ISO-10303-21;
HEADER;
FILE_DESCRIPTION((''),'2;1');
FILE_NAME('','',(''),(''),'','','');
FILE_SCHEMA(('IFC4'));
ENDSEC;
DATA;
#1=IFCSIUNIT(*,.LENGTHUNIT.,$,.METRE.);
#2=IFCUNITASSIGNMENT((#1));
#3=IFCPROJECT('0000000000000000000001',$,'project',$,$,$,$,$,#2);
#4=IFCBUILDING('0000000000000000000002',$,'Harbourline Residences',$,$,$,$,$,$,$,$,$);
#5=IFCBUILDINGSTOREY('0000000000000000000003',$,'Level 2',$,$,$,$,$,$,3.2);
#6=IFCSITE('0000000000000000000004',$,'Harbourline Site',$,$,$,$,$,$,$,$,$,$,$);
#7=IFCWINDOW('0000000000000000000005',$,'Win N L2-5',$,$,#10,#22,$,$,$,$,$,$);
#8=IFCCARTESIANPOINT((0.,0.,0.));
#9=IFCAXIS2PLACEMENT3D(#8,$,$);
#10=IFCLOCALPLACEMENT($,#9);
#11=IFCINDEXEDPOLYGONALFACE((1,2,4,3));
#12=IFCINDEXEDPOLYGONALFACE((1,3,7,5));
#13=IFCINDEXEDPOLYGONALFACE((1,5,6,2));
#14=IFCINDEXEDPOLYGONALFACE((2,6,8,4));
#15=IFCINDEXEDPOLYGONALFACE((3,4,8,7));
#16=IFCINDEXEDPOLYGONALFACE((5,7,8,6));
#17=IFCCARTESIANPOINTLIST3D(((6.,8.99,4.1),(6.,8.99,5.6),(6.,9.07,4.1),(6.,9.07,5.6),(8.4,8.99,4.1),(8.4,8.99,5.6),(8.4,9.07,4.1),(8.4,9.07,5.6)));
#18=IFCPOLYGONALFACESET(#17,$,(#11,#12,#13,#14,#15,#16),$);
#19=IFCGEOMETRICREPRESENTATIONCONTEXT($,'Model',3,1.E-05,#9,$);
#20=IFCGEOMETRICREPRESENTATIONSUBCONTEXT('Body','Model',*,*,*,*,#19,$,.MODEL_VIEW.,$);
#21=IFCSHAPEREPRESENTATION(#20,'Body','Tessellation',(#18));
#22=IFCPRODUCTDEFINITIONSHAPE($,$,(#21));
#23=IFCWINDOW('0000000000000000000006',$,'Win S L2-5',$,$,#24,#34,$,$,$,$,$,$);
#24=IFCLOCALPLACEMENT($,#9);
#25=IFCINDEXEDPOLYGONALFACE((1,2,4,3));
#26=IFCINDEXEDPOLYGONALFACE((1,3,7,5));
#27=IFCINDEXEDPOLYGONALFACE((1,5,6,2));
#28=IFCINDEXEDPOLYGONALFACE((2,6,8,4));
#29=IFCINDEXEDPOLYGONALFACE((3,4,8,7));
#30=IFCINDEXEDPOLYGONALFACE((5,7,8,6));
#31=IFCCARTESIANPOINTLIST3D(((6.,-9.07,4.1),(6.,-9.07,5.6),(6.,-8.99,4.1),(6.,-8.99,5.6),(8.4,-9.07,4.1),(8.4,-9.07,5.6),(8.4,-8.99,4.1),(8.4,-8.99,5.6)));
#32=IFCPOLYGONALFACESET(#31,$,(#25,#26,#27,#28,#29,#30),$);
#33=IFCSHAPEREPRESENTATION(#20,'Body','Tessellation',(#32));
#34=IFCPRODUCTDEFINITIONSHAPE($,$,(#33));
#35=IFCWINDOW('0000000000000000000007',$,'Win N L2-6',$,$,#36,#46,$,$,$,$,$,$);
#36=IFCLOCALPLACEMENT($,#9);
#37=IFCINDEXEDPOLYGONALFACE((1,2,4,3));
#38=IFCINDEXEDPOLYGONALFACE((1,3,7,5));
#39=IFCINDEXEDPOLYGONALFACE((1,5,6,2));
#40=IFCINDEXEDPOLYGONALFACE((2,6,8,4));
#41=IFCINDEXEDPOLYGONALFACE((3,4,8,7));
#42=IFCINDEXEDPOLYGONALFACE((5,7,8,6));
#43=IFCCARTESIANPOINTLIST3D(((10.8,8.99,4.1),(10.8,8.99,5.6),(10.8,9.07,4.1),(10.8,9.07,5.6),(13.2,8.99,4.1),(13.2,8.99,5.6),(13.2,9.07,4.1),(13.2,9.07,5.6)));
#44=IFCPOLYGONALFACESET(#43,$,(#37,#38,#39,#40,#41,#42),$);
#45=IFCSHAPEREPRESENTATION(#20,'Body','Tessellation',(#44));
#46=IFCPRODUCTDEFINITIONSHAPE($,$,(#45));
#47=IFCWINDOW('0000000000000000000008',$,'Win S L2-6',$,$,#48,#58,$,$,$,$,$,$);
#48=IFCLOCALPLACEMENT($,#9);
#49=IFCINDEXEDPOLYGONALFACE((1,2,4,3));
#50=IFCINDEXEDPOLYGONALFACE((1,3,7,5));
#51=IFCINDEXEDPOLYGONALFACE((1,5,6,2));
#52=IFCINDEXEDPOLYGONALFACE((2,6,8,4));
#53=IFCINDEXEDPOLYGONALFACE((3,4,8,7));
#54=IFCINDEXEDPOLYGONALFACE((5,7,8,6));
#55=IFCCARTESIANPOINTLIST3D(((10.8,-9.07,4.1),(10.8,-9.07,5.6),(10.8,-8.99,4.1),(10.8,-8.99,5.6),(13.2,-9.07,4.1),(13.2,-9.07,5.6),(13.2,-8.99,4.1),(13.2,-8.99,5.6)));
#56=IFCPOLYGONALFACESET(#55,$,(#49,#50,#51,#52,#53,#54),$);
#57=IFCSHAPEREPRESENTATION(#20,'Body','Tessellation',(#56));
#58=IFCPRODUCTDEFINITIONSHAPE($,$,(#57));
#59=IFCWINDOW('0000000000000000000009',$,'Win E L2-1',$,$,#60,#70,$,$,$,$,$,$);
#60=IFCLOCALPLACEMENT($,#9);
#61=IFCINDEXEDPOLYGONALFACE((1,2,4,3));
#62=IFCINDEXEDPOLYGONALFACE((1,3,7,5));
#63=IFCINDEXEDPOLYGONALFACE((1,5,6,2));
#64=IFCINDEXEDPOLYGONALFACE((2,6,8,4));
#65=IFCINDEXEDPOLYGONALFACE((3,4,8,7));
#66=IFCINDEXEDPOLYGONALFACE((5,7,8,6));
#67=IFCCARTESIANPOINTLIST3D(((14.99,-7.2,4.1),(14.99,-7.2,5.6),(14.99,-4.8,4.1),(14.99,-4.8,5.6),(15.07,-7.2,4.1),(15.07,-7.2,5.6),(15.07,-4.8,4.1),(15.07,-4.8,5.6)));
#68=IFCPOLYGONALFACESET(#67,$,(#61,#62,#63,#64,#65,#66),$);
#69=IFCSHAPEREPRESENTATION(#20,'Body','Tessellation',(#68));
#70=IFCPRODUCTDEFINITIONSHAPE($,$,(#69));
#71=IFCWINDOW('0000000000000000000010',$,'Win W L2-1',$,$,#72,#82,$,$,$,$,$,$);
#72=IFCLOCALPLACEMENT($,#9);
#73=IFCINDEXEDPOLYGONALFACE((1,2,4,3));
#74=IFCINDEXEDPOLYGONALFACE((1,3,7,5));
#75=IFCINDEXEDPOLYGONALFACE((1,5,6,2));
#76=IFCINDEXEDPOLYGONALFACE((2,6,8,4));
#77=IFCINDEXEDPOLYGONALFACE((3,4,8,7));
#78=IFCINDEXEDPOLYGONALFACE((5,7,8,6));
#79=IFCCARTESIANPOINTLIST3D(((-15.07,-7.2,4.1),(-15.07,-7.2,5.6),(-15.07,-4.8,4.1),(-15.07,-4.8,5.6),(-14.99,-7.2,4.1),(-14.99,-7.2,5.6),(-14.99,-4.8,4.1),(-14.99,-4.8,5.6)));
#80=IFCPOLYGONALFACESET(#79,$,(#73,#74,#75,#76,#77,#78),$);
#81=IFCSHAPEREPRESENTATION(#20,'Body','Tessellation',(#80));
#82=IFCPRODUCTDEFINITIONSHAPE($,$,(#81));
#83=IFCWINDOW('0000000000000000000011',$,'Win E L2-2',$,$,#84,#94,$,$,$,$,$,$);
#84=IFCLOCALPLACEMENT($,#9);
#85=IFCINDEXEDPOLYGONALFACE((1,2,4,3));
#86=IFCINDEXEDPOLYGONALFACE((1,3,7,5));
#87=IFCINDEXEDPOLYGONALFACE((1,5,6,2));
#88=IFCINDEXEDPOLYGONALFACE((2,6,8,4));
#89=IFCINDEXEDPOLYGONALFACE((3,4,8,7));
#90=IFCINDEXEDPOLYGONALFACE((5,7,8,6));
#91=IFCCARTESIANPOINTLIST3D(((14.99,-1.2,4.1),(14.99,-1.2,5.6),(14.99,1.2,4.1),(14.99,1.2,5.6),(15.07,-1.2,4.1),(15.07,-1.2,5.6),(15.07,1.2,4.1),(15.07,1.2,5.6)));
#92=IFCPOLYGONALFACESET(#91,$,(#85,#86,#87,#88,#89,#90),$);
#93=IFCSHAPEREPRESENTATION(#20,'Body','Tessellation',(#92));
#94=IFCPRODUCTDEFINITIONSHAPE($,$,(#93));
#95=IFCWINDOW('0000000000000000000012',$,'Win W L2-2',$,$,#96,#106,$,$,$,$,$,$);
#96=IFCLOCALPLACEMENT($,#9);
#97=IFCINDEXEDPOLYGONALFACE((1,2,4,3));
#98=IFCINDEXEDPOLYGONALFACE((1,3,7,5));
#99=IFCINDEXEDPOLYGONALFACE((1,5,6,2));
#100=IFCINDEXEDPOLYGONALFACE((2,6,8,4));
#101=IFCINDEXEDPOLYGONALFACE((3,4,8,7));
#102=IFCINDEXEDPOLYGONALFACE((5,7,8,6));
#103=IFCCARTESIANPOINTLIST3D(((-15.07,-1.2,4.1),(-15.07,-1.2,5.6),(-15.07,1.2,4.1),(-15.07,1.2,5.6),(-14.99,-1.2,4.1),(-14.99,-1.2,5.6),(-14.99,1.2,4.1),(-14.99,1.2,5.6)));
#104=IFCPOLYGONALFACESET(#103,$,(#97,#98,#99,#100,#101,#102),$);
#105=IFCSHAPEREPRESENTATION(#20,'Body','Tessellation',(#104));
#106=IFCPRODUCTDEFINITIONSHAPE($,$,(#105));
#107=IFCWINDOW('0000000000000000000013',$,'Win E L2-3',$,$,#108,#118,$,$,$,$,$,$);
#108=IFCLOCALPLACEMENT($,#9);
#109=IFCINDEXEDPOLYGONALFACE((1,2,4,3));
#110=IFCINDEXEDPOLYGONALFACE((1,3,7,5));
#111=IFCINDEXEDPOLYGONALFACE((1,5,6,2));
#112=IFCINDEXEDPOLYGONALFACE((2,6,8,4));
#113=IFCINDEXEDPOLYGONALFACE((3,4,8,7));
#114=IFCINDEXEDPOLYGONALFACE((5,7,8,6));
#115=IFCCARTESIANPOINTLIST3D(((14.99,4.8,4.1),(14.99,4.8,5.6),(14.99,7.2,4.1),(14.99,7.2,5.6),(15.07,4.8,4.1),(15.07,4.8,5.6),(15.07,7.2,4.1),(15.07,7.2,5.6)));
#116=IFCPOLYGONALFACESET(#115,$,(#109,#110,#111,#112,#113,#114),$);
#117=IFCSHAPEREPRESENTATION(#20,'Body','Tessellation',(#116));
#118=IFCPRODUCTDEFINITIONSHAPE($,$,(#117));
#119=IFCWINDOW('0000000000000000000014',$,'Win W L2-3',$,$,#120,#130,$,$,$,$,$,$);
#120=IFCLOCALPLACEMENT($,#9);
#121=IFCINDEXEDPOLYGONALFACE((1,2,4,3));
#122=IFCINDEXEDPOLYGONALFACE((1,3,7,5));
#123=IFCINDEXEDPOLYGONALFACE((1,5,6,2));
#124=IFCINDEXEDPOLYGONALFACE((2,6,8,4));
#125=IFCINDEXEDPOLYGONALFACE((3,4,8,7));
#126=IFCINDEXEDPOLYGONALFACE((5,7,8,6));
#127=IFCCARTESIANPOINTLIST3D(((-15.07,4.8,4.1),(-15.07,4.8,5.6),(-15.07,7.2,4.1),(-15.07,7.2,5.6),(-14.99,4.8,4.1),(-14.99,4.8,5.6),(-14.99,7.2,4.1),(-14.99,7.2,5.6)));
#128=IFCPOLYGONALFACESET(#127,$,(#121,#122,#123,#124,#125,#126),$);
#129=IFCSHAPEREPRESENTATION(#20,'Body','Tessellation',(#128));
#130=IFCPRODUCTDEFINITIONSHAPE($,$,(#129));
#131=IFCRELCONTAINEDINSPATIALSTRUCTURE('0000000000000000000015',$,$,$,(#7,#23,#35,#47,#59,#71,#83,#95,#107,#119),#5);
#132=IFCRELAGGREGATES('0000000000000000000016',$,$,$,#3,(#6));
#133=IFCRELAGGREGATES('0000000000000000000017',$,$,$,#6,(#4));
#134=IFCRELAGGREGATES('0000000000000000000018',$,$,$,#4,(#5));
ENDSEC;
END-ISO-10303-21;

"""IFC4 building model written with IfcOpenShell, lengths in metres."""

from ifc_helpers import new_model, si_unit, frame, frame_2d, origin, context, subcontext, project, spatial, rectangle, extrude, element, save


model = new_model("IFC4")

# Units and contexts
model_context = context("Model", 3, precision=1e-05, world=origin())
body_context = subcontext(model_context, "Body", "Model", "MODEL_VIEW")
ifc_project = project(units=[si_unit("LENGTHUNIT", "METRE")])

# Site, building, storey
site = spatial("IfcSite", under=ifc_project, Name="Harbourline Site")
building = spatial("IfcBuilding", under=site, Name="Harbourline Residences")
storey = spatial("IfcBuildingStorey", under=building, Name="Level 2", Elevation=3.2)

# Windows
element("IfcWindow", 1, inside=storey, Name="Win N L2-5", context=body_context, shape_type="SweptSolid", body=[
    extrude(rectangle(XDim=2.4, YDim=0.08, at=frame_2d((7.2, 9.03))), frame((0.0, 0.0, 4.1)), (0.0, 0.0, 1.0), 1.5),
])
element("IfcWindow", 2, inside=storey, Name="Win S L2-5", context=body_context, shape_type="SweptSolid", body=[
    extrude(rectangle(XDim=2.4, YDim=0.08, at=frame_2d((7.2, -9.03))), frame((0.0, 0.0, 4.1)), (0.0, 0.0, 1.0), 1.5),
])
element("IfcWindow", 3, inside=storey, Name="Win N L2-6", context=body_context, shape_type="SweptSolid", body=[
    extrude(rectangle(XDim=2.4, YDim=0.08, at=frame_2d((12.0, 9.03))), frame((0.0, 0.0, 4.1)), (0.0, 0.0, 1.0), 1.5),
])
element("IfcWindow", 4, inside=storey, Name="Win S L2-6", context=body_context, shape_type="SweptSolid", body=[
    extrude(rectangle(XDim=2.4, YDim=0.08, at=frame_2d((12.0, -9.03))), frame((0.0, 0.0, 4.1)), (0.0, 0.0, 1.0), 1.5),
])
element("IfcWindow", 5, inside=storey, Name="Win E L2-1", context=body_context, shape_type="SweptSolid", body=[
    extrude(rectangle(XDim=0.08, YDim=2.4, at=frame_2d((15.03, -6.0))), frame((0.0, 0.0, 4.1)), (0.0, 0.0, 1.0), 1.5),
])
element("IfcWindow", 6, inside=storey, Name="Win W L2-1", context=body_context, shape_type="SweptSolid", body=[
    extrude(rectangle(XDim=0.08, YDim=2.4, at=frame_2d((-15.03, -6.0))), frame((0.0, 0.0, 4.1)), (0.0, 0.0, 1.0), 1.5),
])
element("IfcWindow", 7, inside=storey, Name="Win E L2-2", context=body_context, shape_type="SweptSolid", body=[
    extrude(rectangle(XDim=0.08, YDim=2.4, at=frame_2d((15.03, 0.0))), frame((0.0, 0.0, 4.1)), (0.0, 0.0, 1.0), 1.5),
])
element("IfcWindow", 8, inside=storey, Name="Win W L2-2", context=body_context, shape_type="SweptSolid", body=[
    extrude(rectangle(XDim=0.08, YDim=2.4, at=frame_2d((-15.03, 0.0))), frame((0.0, 0.0, 4.1)), (0.0, 0.0, 1.0), 1.5),
])
element("IfcWindow", 9, inside=storey, Name="Win E L2-3", context=body_context, shape_type="SweptSolid", body=[
    extrude(rectangle(XDim=0.08, YDim=2.4, at=frame_2d((15.03, 6.0))), frame((0.0, 0.0, 4.1)), (0.0, 0.0, 1.0), 1.5),
])
element("IfcWindow", 10, inside=storey, Name="Win W L2-3", context=body_context, shape_type="SweptSolid", body=[
    extrude(rectangle(XDim=0.08, YDim=2.4, at=frame_2d((-15.03, 6.0))), frame((0.0, 0.0, 4.1)), (0.0, 0.0, 1.0), 1.5),
])

save(model, "model.ifc")
